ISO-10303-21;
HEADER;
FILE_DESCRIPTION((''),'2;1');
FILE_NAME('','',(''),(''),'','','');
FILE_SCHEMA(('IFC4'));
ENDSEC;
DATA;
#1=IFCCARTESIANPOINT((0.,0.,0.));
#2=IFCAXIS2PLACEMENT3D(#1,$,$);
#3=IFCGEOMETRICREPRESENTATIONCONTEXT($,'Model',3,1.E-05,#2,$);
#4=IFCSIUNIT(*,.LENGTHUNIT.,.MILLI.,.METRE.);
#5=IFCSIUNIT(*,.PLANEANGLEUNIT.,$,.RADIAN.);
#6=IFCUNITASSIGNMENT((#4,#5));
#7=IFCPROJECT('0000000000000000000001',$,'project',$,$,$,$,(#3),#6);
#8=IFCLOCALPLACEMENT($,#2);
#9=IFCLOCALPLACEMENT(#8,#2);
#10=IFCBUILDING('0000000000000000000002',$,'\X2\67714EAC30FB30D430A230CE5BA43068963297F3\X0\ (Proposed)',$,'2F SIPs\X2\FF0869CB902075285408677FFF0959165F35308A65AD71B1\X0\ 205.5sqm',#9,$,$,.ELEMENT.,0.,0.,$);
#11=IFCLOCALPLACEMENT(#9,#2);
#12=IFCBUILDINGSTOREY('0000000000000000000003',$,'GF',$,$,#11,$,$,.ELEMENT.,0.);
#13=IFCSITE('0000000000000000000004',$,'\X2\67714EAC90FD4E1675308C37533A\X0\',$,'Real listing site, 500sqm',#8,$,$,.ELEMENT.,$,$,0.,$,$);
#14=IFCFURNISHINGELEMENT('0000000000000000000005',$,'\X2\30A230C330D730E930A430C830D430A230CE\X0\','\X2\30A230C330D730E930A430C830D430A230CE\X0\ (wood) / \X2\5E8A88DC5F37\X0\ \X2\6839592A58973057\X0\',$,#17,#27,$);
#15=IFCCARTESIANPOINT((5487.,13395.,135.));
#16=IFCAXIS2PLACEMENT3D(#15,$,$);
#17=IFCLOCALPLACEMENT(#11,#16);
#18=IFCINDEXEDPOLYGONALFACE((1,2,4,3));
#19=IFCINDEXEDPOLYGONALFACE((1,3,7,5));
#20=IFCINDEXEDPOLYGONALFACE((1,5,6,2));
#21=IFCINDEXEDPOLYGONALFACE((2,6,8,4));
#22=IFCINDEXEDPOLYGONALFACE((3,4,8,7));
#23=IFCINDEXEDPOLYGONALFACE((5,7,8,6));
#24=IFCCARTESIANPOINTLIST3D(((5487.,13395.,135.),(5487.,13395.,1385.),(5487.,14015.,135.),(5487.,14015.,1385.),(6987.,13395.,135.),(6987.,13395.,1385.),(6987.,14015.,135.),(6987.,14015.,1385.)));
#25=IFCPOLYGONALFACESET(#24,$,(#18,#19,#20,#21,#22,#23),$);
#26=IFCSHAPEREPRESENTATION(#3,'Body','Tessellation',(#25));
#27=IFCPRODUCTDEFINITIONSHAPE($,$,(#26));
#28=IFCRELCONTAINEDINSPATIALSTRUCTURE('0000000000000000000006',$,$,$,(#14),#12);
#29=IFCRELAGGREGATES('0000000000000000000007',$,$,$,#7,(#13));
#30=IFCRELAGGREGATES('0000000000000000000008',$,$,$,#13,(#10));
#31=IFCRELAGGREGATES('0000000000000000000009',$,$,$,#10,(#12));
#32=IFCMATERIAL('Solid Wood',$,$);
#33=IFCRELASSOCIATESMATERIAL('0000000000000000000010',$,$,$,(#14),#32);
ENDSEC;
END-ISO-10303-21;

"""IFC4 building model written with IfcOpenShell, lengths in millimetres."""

from ifc_helpers import new_model, si_unit, frame, frame_2d, origin, place, context, project, spatial, rectangle, extrude, material, element, save


model = new_model("IFC4")

# Units and contexts
model_context = context("Model", 3, precision=1e-05, world=origin())
ifc_project = project(units=[si_unit("LENGTHUNIT", "METRE", prefix="MILLI"), si_unit("PLANEANGLEUNIT", "RADIAN")], contexts=[model_context])

# Site, building, storey
site_placement = place(None, origin())
site = spatial("IfcSite", under=ifc_project, at=site_placement, Name="東京都世田谷区", ObjectType="Real listing site, 500sqm", CompositionType="ELEMENT", RefElevation=0.0)
building_placement = place(site_placement, origin())
building = spatial("IfcBuilding", under=site, at=building_placement, Name="東京・ピアノ室と防音 (Proposed)", ObjectType="2F SIPs（構造用合板）外張り断熱 205.5sqm", CompositionType="ELEMENT", ElevationOfRefHeight=0.0, ElevationOfTerrain=0.0)
storey_placement = place(building_placement, origin())
storey = spatial("IfcBuildingStorey", under=building, at=storey_placement, Name="GF", CompositionType="ELEMENT", Elevation=0.0)

# Shared definitions
ifc_material_1 = material(Name="Solid Wood")

# Furnishing element
furnishing_1_placement = place(storey_placement, frame((5487.0, 13395.0, 135.0)))
element("IfcFurnishingElement", 1, at=furnishing_1_placement, inside=storey, material=ifc_material_1, Name="アップライトピアノ", Description="アップライトピアノ (wood) / 床補強 根太増し", context=model_context, shape_type="SweptSolid", body=[
    extrude(rectangle(XDim=1500.0, YDim=620.0, at=frame_2d((750.0, 310.0))), frame((5487.0, 13395.0, 135.0)), (0.0, 0.0, 1.0), 1250.0),
])

save(model, "model.ifc")
